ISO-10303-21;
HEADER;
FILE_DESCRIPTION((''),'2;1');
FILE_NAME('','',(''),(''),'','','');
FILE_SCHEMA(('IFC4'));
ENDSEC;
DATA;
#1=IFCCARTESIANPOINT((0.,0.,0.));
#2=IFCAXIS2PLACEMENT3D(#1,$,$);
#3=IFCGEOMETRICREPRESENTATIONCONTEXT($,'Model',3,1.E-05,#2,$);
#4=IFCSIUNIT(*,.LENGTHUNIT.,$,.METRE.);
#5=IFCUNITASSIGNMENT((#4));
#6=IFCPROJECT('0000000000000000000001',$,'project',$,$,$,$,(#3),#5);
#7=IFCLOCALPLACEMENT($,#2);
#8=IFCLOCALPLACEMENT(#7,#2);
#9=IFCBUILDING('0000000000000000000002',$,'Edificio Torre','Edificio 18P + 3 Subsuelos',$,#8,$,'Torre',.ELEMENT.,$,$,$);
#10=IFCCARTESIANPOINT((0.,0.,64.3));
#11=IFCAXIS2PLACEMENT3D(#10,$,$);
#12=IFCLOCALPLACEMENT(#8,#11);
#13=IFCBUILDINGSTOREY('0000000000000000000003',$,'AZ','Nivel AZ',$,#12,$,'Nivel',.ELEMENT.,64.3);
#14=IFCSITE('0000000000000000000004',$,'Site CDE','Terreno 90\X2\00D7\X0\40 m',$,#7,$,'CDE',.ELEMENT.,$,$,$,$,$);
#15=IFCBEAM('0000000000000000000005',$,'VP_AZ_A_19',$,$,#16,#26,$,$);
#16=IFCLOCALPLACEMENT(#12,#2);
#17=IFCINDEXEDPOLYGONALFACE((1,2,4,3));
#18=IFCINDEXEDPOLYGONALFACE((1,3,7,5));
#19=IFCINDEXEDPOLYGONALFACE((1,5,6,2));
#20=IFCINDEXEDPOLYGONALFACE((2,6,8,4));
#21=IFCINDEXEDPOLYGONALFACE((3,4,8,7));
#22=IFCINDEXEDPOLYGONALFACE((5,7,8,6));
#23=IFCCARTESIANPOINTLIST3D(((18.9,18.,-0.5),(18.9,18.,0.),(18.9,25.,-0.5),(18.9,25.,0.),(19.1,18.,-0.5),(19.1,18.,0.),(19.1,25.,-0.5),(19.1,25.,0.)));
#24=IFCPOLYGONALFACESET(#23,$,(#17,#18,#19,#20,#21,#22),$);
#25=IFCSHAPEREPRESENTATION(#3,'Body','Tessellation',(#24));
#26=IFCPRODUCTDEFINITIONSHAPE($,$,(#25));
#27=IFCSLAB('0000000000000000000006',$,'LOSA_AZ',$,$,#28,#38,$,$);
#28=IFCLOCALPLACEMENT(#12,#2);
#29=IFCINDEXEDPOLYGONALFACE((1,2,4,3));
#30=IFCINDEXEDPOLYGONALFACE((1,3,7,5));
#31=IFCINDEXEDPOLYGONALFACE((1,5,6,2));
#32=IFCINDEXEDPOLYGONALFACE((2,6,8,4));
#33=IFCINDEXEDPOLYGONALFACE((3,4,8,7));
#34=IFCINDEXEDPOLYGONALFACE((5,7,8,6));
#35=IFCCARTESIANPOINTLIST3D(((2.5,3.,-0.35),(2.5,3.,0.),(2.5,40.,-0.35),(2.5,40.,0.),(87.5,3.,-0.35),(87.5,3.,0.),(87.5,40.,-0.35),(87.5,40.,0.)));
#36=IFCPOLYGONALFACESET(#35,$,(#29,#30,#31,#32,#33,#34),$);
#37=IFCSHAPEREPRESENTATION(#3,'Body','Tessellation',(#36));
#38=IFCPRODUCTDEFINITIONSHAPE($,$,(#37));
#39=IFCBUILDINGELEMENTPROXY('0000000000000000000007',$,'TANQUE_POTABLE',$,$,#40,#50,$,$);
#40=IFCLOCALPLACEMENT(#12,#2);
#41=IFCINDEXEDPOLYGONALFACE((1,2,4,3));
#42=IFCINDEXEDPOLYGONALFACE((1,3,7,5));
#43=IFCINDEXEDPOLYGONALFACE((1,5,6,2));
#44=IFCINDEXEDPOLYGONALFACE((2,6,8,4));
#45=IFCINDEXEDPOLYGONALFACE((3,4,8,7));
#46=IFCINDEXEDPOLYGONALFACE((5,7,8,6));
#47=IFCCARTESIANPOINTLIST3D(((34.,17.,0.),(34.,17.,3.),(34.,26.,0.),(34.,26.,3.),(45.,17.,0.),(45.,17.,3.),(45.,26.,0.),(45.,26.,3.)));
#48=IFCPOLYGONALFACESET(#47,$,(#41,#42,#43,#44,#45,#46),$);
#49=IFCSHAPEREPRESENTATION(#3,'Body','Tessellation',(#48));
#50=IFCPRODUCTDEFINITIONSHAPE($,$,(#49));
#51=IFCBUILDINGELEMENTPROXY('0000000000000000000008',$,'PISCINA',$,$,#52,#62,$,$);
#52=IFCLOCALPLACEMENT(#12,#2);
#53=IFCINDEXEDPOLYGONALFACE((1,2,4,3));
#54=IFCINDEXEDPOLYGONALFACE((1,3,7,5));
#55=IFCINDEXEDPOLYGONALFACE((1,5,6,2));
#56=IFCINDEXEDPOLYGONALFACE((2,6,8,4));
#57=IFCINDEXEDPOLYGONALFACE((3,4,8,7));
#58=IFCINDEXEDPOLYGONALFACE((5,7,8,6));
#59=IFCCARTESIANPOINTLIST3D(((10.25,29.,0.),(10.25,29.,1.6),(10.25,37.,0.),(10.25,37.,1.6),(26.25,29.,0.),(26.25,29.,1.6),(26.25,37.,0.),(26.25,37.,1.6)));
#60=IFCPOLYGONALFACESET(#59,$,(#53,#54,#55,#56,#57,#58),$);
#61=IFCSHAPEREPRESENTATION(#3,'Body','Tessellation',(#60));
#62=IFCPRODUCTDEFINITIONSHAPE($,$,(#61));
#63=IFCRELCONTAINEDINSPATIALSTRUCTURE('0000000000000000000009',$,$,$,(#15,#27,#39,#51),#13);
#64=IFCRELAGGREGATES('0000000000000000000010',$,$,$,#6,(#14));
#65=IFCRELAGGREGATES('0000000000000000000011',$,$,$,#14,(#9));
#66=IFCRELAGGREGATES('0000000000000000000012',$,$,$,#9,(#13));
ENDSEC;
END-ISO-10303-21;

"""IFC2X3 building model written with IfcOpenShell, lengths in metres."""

from ifc_helpers import new_model, si_unit, frame, origin, origin_2d, place, context, project, spatial, rectangle, extrude, element, save


model = new_model("IFC2X3")

# Units and contexts
model_context = context("Model", 3, precision=1e-05, world=origin())
ifc_project = project(units=[si_unit("LENGTHUNIT", "METRE")], contexts=[model_context])

# Site, building, storey
site_placement = place(None, origin())
site = spatial("IfcSite", under=ifc_project, at=site_placement, Name="Site CDE", Description="Terreno 90×40 m", LongName="CDE", CompositionType="ELEMENT")
building_placement = place(site_placement, origin())
building = spatial("IfcBuilding", under=site, at=building_placement, Name="Edificio Torre", Description="Edificio 18P + 3 Subsuelos", LongName="Torre", CompositionType="ELEMENT")
storey_placement = place(building_placement, frame((0.0, 0.0, 64.3)))
storey = spatial("IfcBuildingStorey", under=building, at=storey_placement, Name="AZ", Description="Nivel AZ", LongName="Nivel", CompositionType="ELEMENT", Elevation=64.3)

# Beam
beam_1_placement = place(storey_placement, frame((19.0, 21.5, -0.5)))
element("IfcBeam", 1, at=beam_1_placement, inside=storey, Name="VP_AZ_A_19", context=model_context, shape_type="SweptSolid", body=[
    extrude(rectangle(XDim=0.2, YDim=7.0, at=origin_2d()), origin(), (0.0, 0.0, 1.0), 0.5),
])

# Slab
slab_placement = place(storey_placement, frame((45.0, 21.5, -0.35)))
element("IfcSlab", 2, at=slab_placement, inside=storey, Name="LOSA_AZ", context=model_context, shape_type="SweptSolid", body=[
    extrude(rectangle(XDim=85.0, YDim=37.0, at=origin_2d()), origin(), (0.0, 0.0, 1.0), 0.35),
])

# Building element proxies
proxy_1_placement = place(storey_placement, frame((39.5, 21.5, 0.0)))
element("IfcBuildingElementProxy", 3, at=proxy_1_placement, inside=storey, Name="TANQUE_POTABLE", context=model_context, shape_type="SweptSolid", body=[
    extrude(rectangle(XDim=11.0, YDim=9.0, at=origin_2d()), origin(), (0.0, 0.0, 1.0), 3.0),
])
proxy_2_placement = place(storey_placement, frame((18.25, 33.0, 0.0)))
element("IfcBuildingElementProxy", 4, at=proxy_2_placement, inside=storey, Name="PISCINA", context=model_context, shape_type="SweptSolid", body=[
    extrude(rectangle(XDim=16.0, YDim=8.0, at=origin_2d()), origin(), (0.0, 0.0, 1.0), 1.6),
])

save(model, "model.ifc")
